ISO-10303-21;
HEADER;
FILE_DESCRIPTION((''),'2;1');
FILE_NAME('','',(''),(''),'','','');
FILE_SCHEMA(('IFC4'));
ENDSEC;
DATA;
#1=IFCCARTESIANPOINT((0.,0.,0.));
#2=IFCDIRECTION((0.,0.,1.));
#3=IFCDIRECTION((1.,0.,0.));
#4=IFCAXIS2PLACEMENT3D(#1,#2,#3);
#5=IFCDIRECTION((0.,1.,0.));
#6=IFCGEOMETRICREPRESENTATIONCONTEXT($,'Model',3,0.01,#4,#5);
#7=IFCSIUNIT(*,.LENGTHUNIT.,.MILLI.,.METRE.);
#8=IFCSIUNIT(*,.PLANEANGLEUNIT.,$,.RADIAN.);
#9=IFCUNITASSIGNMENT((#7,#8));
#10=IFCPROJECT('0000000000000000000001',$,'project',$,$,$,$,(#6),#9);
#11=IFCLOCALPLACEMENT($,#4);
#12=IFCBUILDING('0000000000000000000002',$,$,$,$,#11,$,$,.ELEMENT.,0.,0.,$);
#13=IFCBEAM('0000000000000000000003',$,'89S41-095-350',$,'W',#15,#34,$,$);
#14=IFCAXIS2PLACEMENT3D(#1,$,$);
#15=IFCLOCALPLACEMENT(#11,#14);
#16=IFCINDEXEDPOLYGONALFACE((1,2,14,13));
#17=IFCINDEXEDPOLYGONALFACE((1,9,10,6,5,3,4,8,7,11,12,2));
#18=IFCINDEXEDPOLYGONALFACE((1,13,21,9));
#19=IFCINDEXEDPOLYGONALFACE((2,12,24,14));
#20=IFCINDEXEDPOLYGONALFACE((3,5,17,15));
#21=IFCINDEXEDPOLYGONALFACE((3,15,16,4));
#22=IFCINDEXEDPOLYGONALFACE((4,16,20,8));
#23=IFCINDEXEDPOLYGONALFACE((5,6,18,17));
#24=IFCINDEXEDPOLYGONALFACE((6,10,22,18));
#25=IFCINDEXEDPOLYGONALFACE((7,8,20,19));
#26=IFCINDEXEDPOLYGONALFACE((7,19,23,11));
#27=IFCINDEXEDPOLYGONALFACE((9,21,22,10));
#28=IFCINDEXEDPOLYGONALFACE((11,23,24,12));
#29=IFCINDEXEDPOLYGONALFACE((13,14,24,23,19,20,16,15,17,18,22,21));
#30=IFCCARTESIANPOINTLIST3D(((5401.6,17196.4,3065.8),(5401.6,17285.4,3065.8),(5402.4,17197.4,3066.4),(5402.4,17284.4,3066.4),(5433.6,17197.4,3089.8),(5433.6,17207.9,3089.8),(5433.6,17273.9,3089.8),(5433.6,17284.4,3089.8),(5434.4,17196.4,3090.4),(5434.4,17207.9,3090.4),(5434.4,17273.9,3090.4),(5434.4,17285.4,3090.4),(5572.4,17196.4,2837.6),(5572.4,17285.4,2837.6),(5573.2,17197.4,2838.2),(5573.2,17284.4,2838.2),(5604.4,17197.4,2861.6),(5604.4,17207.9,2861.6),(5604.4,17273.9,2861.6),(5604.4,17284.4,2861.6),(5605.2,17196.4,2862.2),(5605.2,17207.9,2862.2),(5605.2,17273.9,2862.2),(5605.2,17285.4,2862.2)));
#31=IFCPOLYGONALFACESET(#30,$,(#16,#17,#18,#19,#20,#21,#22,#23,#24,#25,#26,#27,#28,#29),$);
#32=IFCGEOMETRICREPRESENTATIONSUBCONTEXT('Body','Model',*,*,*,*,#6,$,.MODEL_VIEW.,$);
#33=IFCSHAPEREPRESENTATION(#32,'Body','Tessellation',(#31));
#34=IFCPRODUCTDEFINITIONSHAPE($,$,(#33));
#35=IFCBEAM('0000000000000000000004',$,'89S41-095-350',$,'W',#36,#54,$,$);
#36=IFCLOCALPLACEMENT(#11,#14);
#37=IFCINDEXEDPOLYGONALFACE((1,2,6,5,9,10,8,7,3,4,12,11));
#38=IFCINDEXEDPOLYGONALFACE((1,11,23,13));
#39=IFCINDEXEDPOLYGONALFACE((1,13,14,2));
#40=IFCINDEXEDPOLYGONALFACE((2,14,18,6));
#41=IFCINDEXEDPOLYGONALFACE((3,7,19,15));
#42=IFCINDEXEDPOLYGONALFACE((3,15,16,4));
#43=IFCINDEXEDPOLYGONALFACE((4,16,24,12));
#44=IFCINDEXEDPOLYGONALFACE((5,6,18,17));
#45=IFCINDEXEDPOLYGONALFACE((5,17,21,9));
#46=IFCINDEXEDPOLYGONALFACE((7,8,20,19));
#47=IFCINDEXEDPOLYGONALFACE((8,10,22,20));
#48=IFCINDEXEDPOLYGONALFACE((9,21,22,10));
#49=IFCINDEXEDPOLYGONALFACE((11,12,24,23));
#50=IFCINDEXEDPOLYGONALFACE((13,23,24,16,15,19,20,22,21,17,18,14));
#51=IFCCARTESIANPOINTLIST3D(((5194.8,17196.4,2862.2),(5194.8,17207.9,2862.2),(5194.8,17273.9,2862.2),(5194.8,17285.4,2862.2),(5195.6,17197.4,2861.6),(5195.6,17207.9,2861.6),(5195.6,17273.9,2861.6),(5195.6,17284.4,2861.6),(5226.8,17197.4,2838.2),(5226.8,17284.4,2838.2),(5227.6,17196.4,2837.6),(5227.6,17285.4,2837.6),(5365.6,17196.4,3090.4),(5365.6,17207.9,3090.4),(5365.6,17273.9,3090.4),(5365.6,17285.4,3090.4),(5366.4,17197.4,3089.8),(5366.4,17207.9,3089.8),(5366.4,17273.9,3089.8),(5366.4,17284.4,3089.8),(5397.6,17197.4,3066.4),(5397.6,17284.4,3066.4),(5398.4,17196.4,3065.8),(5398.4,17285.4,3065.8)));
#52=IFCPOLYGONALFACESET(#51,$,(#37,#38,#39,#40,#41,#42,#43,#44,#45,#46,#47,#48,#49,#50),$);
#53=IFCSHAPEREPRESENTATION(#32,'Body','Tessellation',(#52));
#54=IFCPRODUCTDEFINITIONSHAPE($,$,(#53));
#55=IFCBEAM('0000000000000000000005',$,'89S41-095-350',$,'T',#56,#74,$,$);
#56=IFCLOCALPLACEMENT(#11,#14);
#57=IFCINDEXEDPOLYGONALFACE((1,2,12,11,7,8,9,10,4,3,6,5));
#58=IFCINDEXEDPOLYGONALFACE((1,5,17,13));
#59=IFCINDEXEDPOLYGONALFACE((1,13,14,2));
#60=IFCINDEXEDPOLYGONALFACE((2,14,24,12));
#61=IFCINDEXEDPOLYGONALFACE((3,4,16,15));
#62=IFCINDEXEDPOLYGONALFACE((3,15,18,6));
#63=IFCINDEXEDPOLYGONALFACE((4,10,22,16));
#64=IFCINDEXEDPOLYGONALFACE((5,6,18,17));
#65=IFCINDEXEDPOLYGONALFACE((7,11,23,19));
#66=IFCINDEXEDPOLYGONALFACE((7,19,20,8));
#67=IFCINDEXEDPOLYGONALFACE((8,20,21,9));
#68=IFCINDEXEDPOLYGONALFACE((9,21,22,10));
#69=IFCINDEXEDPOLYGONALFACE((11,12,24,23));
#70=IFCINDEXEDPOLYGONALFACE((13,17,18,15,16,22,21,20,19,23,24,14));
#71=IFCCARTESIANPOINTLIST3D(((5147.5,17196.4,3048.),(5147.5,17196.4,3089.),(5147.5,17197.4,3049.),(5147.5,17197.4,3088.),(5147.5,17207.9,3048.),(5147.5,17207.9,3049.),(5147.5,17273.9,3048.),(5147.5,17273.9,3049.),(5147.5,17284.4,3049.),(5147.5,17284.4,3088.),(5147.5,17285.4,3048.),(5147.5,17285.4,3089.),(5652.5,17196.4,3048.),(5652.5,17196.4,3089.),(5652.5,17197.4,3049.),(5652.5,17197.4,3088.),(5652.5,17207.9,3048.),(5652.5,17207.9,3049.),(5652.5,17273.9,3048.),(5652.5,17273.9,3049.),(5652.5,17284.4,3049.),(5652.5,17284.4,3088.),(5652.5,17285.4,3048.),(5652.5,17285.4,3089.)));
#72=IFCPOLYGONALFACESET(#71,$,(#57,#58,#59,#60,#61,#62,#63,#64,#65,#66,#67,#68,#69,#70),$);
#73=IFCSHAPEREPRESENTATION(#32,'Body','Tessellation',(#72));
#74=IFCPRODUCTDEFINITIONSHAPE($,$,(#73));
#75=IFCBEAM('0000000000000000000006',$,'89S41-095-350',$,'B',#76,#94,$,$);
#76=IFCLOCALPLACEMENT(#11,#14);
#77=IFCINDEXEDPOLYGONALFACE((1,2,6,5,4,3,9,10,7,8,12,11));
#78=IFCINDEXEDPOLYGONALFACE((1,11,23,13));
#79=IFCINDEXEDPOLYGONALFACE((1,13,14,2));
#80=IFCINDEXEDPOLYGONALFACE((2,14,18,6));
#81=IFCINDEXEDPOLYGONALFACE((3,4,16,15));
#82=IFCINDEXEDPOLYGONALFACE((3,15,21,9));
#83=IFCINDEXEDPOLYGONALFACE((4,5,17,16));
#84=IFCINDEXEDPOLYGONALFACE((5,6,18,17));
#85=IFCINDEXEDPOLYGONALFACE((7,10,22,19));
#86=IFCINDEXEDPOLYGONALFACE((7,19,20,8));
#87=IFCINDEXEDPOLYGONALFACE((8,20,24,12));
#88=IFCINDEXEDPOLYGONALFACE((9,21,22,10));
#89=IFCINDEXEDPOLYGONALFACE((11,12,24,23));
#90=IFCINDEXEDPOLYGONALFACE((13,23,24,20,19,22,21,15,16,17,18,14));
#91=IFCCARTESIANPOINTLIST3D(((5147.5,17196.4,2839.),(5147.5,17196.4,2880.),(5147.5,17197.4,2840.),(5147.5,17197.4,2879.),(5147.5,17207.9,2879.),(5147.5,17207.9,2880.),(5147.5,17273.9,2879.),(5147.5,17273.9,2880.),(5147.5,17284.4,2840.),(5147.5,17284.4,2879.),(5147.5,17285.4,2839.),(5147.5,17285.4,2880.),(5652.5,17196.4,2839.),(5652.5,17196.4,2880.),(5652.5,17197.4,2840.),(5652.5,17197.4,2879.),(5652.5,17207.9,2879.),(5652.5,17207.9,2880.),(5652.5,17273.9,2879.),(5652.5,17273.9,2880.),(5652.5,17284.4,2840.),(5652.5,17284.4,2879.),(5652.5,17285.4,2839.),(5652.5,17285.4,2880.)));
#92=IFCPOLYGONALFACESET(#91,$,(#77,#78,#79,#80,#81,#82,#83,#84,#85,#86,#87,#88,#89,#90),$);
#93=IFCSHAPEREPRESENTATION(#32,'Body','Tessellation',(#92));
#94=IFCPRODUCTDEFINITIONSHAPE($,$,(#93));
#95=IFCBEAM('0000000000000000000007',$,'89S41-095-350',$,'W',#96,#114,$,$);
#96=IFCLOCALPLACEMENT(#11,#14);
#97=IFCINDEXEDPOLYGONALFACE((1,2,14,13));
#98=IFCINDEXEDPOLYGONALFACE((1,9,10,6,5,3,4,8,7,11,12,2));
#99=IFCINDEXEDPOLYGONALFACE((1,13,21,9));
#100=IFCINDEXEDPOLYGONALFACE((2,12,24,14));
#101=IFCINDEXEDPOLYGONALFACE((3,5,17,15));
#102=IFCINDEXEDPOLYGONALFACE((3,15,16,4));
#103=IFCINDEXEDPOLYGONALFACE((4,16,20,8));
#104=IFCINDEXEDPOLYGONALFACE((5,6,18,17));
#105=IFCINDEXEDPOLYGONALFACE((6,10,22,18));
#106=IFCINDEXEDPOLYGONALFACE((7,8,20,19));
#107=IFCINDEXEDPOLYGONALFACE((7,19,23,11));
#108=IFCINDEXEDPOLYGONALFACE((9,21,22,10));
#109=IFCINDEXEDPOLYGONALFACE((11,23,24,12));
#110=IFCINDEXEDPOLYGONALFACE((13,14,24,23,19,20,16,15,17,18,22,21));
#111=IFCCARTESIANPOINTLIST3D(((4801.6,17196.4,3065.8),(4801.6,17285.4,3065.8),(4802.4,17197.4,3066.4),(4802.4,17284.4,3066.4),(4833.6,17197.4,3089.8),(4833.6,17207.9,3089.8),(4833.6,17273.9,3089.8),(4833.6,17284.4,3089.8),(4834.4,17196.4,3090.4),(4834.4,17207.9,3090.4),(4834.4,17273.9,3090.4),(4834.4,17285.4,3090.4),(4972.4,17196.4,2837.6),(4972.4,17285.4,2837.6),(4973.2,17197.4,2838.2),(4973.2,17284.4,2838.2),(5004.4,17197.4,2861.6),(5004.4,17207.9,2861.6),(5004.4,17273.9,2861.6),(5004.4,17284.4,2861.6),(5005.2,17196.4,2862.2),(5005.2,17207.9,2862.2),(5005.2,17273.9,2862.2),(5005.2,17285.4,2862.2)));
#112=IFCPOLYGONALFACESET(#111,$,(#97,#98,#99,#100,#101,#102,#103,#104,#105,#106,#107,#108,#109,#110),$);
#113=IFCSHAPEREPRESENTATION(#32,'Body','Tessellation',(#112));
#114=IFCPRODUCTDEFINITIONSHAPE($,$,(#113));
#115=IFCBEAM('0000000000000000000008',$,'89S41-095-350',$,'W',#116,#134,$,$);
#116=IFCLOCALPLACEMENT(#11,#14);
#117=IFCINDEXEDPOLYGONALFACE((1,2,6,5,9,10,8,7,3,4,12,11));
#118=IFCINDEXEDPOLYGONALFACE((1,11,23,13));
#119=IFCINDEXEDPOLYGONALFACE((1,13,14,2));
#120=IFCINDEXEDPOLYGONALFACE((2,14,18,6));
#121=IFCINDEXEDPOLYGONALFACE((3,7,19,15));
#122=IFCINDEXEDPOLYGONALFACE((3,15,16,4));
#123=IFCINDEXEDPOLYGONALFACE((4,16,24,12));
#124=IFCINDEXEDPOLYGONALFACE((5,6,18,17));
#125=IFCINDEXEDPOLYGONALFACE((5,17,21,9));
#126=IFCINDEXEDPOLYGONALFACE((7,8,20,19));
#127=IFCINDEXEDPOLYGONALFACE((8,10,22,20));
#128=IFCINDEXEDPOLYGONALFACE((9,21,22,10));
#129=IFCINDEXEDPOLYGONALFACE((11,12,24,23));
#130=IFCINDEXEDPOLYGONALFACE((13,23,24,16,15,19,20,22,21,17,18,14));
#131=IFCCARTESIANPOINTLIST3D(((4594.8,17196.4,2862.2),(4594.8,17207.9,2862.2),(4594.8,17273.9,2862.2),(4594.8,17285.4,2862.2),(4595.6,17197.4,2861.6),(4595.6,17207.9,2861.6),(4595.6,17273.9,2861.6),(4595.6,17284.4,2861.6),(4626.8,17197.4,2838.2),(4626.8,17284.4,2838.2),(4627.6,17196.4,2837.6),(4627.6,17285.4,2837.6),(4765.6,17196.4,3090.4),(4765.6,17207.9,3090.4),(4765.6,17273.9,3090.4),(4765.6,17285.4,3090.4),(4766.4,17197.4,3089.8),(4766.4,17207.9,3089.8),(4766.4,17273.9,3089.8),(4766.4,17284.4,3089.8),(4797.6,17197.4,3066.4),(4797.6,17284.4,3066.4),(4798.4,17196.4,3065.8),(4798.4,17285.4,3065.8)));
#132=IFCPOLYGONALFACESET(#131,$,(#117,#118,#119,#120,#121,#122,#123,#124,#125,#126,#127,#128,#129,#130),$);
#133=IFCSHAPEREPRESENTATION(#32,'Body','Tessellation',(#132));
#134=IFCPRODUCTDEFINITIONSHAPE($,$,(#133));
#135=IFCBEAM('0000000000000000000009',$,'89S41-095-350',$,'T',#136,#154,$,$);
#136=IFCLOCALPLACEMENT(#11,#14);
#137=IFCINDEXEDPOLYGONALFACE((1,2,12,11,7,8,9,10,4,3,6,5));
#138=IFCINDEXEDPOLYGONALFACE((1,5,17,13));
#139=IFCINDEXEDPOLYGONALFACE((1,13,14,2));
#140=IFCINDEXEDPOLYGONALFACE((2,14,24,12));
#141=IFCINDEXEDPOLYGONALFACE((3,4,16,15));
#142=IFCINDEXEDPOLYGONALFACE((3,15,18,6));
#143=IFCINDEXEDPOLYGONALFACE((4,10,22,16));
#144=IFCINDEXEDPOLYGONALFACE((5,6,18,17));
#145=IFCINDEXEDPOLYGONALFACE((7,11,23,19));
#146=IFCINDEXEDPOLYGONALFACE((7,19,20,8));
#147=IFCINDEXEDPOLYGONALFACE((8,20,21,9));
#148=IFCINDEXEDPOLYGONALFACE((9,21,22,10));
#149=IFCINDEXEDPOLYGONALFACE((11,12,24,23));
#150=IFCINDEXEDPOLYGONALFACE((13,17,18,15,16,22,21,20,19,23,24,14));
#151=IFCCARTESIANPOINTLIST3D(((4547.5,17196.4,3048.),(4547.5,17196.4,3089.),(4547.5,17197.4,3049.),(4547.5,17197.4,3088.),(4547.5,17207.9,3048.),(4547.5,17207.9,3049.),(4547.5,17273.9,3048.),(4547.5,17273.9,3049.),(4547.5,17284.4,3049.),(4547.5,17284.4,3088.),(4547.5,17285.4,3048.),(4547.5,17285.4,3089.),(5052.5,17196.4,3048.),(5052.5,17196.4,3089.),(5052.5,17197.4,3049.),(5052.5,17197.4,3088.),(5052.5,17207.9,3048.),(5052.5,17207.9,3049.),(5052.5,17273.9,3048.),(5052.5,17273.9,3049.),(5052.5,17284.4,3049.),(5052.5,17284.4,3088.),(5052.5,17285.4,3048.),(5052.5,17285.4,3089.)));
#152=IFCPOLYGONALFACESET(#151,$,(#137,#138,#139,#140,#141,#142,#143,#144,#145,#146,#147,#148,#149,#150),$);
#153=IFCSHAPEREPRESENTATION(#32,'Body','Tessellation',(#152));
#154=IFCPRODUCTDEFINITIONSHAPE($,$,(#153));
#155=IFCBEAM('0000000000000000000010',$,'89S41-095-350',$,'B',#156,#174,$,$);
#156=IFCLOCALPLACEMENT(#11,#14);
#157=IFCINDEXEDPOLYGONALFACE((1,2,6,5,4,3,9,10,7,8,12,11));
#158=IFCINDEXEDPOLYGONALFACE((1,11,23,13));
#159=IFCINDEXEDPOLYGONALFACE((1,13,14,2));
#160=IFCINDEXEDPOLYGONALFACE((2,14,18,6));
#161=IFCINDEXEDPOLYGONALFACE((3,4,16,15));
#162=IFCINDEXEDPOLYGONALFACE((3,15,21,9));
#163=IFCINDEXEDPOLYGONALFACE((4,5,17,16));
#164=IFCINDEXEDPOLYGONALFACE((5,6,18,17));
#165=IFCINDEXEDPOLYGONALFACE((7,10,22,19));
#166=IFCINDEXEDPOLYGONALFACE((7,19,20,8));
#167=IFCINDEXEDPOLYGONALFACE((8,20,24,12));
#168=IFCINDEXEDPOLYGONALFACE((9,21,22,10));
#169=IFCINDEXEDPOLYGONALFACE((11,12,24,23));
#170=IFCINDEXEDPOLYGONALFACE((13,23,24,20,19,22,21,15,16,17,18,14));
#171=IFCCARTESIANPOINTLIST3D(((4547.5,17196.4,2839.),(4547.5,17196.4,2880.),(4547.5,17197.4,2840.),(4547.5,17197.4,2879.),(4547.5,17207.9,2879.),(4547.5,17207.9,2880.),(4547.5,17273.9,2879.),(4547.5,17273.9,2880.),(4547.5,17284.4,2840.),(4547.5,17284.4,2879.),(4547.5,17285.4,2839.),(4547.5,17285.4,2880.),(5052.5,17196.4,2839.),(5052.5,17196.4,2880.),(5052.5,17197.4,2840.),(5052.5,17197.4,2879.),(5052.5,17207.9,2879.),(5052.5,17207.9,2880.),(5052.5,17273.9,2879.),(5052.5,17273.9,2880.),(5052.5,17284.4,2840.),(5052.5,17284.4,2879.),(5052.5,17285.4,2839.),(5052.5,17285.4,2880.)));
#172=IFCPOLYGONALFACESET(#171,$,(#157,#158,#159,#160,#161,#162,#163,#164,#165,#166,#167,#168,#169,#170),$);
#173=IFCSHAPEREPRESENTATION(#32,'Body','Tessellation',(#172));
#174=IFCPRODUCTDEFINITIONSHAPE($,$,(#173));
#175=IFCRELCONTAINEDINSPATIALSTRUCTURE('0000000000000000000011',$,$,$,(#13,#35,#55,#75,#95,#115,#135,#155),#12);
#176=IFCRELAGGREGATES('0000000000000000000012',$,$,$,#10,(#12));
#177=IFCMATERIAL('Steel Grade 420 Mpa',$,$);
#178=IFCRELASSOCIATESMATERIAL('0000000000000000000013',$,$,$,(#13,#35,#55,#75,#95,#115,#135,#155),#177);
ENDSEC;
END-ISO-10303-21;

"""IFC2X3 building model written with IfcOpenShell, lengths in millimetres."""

from ifc_helpers import new_model, si_unit, direction, frame, origin, origin_with_axes, origin_2d_with_axis, place, context, subcontext, project, spatial, c_section, extrude, source, transform, mapped, material, element, save


model = new_model("IFC2X3")

# Units and contexts
model_context = context("Model", 3, precision=0.01, world=origin_with_axes(), true_north=direction((0.0, 1.0, 0.0)))
body_context = subcontext(model_context, "Body", "Model", "MODEL_VIEW")
ifc_project = project(units=[si_unit("LENGTHUNIT", "METRE", prefix="MILLI"), si_unit("PLANEANGLEUNIT", "RADIAN")], contexts=[model_context])

# Building
building_placement = place(None, origin_with_axes())
building = spatial("IfcBuilding", under=ifc_project, at=building_placement, CompositionType="ELEMENT", ElevationOfRefHeight=0.0, ElevationOfTerrain=0.0)

# Shared definitions
ifc_material = material(Name="Steel Grade 420 Mpa")

# Beams
shared_shape_1 = source(origin(), body_context, "Body", "SweptSolid", [
    extrude(c_section(Depth=89.0, Width=41.0, WallThickness=1.0, Girth=11.5, at=origin_2d_with_axis()), origin_with_axes(), (0.0, 0.0, 1.0), 285.1),
])
beam_1_placement = place(None, frame((5418.0, 17240.9, 3078.1), z_axis=(0.599182, 0.0, -0.800613), x_axis=(0.800613, 0.0, 0.599182)))
element("IfcBeam", 1, at=beam_1_placement, inside=building, material=ifc_material, Name="89S41-095-350", ObjectType="W", context=body_context, shape_type="MappedRepresentation", body=[
    mapped(shared_shape_1, transform((0.0, 0.0, 0.0), scale=1.0)),
])
shared_shape_2 = source(origin(), body_context, "Body", "SweptSolid", [
    extrude(c_section(Depth=89.0, Width=41.0, WallThickness=1.0, Girth=11.5, at=origin_2d_with_axis()), origin_with_axes(), (0.0, 0.0, 1.0), 285.1),
])
beam_2_placement = place(None, frame((5211.2, 17240.9, 2849.9), z_axis=(0.599182, 0.0, 0.800613), x_axis=(-0.800613, 0.0, 0.599182)))
element("IfcBeam", 2, at=beam_2_placement, inside=building, material=ifc_material, Name="89S41-095-350", ObjectType="W", context=body_context, shape_type="MappedRepresentation", body=[
    mapped(shared_shape_2, transform((0.0, 0.0, 0.0), scale=1.0)),
])
shared_shape_3 = source(origin(), body_context, "Body", "SweptSolid", [
    extrude(c_section(Depth=89.0, Width=41.0, WallThickness=1.0, Girth=11.5, at=origin_2d_with_axis()), origin_with_axes(), (0.0, 0.0, 1.0), 505.0),
])
beam_3_placement = place(None, frame((5652.5, 17240.9, 3068.5), z_axis=(-1.0, 0.0, 0.0), x_axis=(0.0, 0.0, -1.0)))
element("IfcBeam", 3, at=beam_3_placement, inside=building, material=ifc_material, Name="89S41-095-350", ObjectType="T", context=body_context, shape_type="MappedRepresentation", body=[
    mapped(shared_shape_3, transform((0.0, 0.0, 0.0), scale=1.0)),
])
shared_shape_4 = source(origin(), body_context, "Body", "SweptSolid", [
    extrude(c_section(Depth=89.0, Width=41.0, WallThickness=1.0, Girth=11.5, at=origin_2d_with_axis()), origin_with_axes(), (0.0, 0.0, 1.0), 505.0),
])
beam_4_placement = place(None, frame((5147.5, 17240.9, 2859.5), z_axis=(1.0, 0.0, 0.0), x_axis=(0.0, 0.0, 1.0)))
element("IfcBeam", 4, at=beam_4_placement, inside=building, material=ifc_material, Name="89S41-095-350", ObjectType="B", context=body_context, shape_type="MappedRepresentation", body=[
    mapped(shared_shape_4, transform((0.0, 0.0, 0.0), scale=1.0)),
])
shared_shape_5 = source(origin(), body_context, "Body", "SweptSolid", [
    extrude(c_section(Depth=89.0, Width=41.0, WallThickness=1.0, Girth=11.5, at=origin_2d_with_axis()), origin_with_axes(), (0.0, 0.0, 1.0), 285.1),
])
beam_5_placement = place(None, frame((4818.0, 17240.9, 3078.1), z_axis=(0.599182, 0.0, -0.800613), x_axis=(0.800613, 0.0, 0.599182)))
element("IfcBeam", 5, at=beam_5_placement, inside=building, material=ifc_material, Name="89S41-095-350", ObjectType="W", context=body_context, shape_type="MappedRepresentation", body=[
    mapped(shared_shape_5, transform((0.0, 0.0, 0.0), scale=1.0)),
])
shared_shape_6 = source(origin(), body_context, "Body", "SweptSolid", [
    extrude(c_section(Depth=89.0, Width=41.0, WallThickness=1.0, Girth=11.5, at=origin_2d_with_axis()), origin_with_axes(), (0.0, 0.0, 1.0), 285.1),
])
beam_6_placement = place(None, frame((4611.2, 17240.9, 2849.9), z_axis=(0.599182, 0.0, 0.800613), x_axis=(-0.800613, 0.0, 0.599182)))
element("IfcBeam", 6, at=beam_6_placement, inside=building, material=ifc_material, Name="89S41-095-350", ObjectType="W", context=body_context, shape_type="MappedRepresentation", body=[
    mapped(shared_shape_6, transform((0.0, 0.0, 0.0), scale=1.0)),
])
shared_shape_7 = source(origin(), body_context, "Body", "SweptSolid", [
    extrude(c_section(Depth=89.0, Width=41.0, WallThickness=1.0, Girth=11.5, at=origin_2d_with_axis()), origin_with_axes(), (0.0, 0.0, 1.0), 505.0),
])
beam_7_placement = place(None, frame((5052.5, 17240.9, 3068.5), z_axis=(-1.0, 0.0, 0.0), x_axis=(0.0, 0.0, -1.0)))
element("IfcBeam", 7, at=beam_7_placement, inside=building, material=ifc_material, Name="89S41-095-350", ObjectType="T", context=body_context, shape_type="MappedRepresentation", body=[
    mapped(shared_shape_7, transform((0.0, 0.0, 0.0), scale=1.0)),
])
shared_shape_8 = source(origin(), body_context, "Body", "SweptSolid", [
    extrude(c_section(Depth=89.0, Width=41.0, WallThickness=1.0, Girth=11.5, at=origin_2d_with_axis()), origin_with_axes(), (0.0, 0.0, 1.0), 505.0),
])
beam_8_placement = place(None, frame((4547.5, 17240.9, 2859.5), z_axis=(1.0, 0.0, 0.0), x_axis=(0.0, 0.0, 1.0)))
element("IfcBeam", 8, at=beam_8_placement, inside=building, material=ifc_material, Name="89S41-095-350", ObjectType="B", context=body_context, shape_type="MappedRepresentation", body=[
    mapped(shared_shape_8, transform((0.0, 0.0, 0.0), scale=1.0)),
])

save(model, "model.ifc")
